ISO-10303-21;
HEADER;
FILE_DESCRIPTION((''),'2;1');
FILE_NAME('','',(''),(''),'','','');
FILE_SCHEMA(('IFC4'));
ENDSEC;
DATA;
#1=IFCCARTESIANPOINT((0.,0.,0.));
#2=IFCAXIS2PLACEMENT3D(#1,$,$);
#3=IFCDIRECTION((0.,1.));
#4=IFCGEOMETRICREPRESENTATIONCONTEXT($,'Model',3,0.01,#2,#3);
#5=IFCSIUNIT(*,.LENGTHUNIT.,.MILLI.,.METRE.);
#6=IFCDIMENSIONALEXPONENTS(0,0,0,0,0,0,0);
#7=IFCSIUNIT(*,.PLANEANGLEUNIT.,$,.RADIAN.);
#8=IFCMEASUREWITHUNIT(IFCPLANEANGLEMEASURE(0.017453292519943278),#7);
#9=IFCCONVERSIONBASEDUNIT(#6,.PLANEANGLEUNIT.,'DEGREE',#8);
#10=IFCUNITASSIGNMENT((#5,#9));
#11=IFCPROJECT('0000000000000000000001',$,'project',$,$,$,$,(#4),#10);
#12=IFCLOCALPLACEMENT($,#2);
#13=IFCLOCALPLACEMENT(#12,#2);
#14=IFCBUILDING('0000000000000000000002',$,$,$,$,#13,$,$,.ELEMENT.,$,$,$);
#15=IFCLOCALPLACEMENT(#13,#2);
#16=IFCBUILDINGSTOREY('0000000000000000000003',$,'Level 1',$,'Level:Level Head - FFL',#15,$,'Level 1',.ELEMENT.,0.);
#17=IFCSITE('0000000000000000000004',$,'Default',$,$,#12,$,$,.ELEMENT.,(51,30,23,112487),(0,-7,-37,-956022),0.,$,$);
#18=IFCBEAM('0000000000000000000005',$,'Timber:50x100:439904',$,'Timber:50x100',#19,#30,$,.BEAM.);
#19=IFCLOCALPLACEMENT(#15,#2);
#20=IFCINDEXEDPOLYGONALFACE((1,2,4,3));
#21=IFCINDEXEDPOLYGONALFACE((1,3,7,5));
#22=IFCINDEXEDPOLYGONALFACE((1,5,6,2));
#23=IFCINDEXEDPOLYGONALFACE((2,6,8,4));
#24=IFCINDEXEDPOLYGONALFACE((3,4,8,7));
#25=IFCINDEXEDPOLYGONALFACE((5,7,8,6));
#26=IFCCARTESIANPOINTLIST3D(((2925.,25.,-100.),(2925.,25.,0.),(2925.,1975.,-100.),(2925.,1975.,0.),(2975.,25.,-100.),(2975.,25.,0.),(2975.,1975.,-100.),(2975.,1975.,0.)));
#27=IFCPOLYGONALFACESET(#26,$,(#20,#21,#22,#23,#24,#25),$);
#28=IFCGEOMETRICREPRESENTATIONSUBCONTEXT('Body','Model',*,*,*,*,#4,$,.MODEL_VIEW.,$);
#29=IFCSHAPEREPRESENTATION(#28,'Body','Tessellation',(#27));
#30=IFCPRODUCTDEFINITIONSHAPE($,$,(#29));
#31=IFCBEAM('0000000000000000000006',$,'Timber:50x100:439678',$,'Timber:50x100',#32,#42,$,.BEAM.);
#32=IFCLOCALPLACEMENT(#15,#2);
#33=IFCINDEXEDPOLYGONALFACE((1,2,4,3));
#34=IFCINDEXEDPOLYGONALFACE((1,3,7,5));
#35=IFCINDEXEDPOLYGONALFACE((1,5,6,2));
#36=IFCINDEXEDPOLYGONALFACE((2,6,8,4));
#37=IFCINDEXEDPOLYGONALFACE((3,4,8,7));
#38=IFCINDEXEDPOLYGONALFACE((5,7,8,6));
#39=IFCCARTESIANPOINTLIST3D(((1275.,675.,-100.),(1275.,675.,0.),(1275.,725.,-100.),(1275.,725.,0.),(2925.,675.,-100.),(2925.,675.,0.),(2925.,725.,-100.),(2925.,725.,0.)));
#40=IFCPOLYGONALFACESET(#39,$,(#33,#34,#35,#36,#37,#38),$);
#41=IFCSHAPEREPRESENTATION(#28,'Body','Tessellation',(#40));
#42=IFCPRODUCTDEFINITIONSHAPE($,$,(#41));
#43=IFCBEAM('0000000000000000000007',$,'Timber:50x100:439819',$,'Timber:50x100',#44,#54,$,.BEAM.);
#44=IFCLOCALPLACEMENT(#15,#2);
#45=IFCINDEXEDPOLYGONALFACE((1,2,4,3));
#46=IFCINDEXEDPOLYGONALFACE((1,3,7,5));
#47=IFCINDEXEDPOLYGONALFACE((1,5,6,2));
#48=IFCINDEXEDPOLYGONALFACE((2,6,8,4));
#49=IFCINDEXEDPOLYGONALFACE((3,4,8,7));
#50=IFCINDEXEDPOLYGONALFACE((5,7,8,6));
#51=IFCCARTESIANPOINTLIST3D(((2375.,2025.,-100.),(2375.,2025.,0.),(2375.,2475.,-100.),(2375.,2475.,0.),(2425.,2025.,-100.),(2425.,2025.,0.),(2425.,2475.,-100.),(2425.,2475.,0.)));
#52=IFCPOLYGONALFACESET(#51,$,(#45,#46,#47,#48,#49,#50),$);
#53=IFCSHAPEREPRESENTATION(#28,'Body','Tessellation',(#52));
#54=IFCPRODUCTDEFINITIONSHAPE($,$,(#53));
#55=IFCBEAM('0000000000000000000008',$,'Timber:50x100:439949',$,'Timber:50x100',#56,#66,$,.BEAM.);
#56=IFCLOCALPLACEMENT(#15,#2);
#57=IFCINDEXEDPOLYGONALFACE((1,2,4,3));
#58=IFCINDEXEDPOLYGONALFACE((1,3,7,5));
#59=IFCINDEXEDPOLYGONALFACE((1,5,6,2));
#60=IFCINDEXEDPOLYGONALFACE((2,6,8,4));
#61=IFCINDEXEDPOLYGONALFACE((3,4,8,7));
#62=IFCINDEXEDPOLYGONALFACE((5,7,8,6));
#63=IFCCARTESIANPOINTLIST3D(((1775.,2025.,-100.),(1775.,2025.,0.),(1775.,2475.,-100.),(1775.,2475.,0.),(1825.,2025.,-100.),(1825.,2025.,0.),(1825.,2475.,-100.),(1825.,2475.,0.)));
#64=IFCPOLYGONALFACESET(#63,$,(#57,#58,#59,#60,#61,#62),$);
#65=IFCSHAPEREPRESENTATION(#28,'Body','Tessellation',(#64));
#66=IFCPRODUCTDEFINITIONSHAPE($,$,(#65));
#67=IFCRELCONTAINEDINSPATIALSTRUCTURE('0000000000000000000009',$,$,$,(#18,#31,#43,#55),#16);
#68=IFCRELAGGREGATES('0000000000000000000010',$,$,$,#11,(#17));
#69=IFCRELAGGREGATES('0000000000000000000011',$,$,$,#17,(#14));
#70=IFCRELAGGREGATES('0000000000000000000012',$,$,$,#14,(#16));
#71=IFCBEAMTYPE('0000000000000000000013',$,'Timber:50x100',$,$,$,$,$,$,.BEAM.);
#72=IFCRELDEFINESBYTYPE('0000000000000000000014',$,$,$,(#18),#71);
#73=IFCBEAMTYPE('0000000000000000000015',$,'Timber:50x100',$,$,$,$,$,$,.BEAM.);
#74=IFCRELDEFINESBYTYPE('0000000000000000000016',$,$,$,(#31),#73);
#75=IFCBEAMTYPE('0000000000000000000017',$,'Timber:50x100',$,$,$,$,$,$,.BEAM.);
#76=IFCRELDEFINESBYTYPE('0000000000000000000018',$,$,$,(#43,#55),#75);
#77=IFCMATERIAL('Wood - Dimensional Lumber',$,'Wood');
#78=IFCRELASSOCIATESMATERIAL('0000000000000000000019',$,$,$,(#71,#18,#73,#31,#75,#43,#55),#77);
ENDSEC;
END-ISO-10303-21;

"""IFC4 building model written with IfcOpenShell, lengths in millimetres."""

from ifc_helpers import new_model, entity, si_unit, converted_unit, direction, frame, origin, place, context, subcontext, project, spatial, indexed_curve, outline, extrude, source, transform, mapped, material, type_object, type_shapes, element, save


model = new_model("IFC4")

# Units and contexts
model_context = context("Model", 3, precision=0.01, world=origin(), true_north=direction((0.0, 1.0)))
body_context = subcontext(model_context, "Body", "Model", "MODEL_VIEW")
ifc_project = project(units=[si_unit("LENGTHUNIT", "METRE", prefix="MILLI"), converted_unit("PLANEANGLEUNIT", "DEGREE", entity("IfcPlaneAngleMeasure", 0.017453292519943278), si_unit("PLANEANGLEUNIT", "RADIAN"), dimensions=[0, 0, 0, 0, 0, 0, 0])], contexts=[model_context])

# Site, building, storey
site_placement = place(None, origin())
site = spatial("IfcSite", under=ifc_project, at=site_placement, Name="Default", CompositionType="ELEMENT", RefLatitude=(51, 30, 23, 112487), RefLongitude=(0, -7, -37, -956022), RefElevation=0.0)
building_placement = place(site_placement, origin())
building = spatial("IfcBuilding", under=site, at=building_placement, CompositionType="ELEMENT")
storey_placement = place(building_placement, origin())
storey = spatial("IfcBuildingStorey", under=building, at=storey_placement, Name="Level 1", ObjectType="Level:Level Head - FFL", LongName="Level 1", CompositionType="ELEMENT", Elevation=0.0)

# Beams
ifc_material = material(Name="Wood - Dimensional Lumber", Category="Wood")
beam_type_1 = type_object("IfcBeamType", Name="Timber:50x100", PredefinedType="BEAM", material=ifc_material)
shared_shape_1 = source(origin(), body_context, "Body", "SweptSolid", [
    extrude(outline(indexed_curve([(-975.0, -25.0), (975.0, -25.0), (975.0, 25.0), (-975.0, 25.0), (-975.0, -25.0)], self_intersect=False)), frame((0.0, 0.0, -50.0), z_axis=(0.0, 0.0, 1.0), x_axis=(-1.0, 0.0, 0.0)), (0.0, 0.0, 1.0), 100.0),
])
type_shapes(beam_type_1, [shared_shape_1])
for number, where, z_axis, x_axis, name in (
    (1, (2950.0, 1000.0, -50.0), (0.0, 0.0, 1.0), (0.0, 1.0, 0.0), "Timber:50x100:439904"),
):
    element("IfcBeam", number, at=place(storey_placement, frame(where, z_axis=z_axis, x_axis=x_axis)), inside=storey, type_object=beam_type_1, material=ifc_material, Name=name, ObjectType="Timber:50x100", PredefinedType="BEAM", context=body_context, shape_type="MappedRepresentation", body=[
        mapped(shared_shape_1, transform((0.0, 0.0, 0.0), scale=1.0)),
    ])
beam_type_2 = type_object("IfcBeamType", Name="Timber:50x100", PredefinedType="BEAM", material=ifc_material)
shared_shape_2 = source(origin(), body_context, "Body", "SweptSolid", [
    extrude(outline(indexed_curve([(-825.0, -25.0), (825.0, -25.0), (825.0, 25.0), (-825.0, 25.0), (-825.0, -25.0)], self_intersect=False)), frame((0.0, 0.0, -50.0), z_axis=(0.0, 0.0, 1.0), x_axis=(-1.0, 0.0, 0.0)), (0.0, 0.0, 1.0), 100.0),
])
type_shapes(beam_type_2, [shared_shape_2])
beam_1_placement = place(storey_placement, frame((2100.0, 700.0, -50.0)))
element("IfcBeam", 2, at=beam_1_placement, inside=storey, type_object=beam_type_2, material=ifc_material, Name="Timber:50x100:439678", ObjectType="Timber:50x100", PredefinedType="BEAM", context=body_context, shape_type="MappedRepresentation", body=[
    mapped(shared_shape_2, transform((0.0, 0.0, 0.0), scale=1.0)),
])
beam_type_3 = type_object("IfcBeamType", Name="Timber:50x100", PredefinedType="BEAM", material=ifc_material)
shared_shape_3 = source(origin(), body_context, "Body", "SweptSolid", [
    extrude(outline(indexed_curve([(-225.0, -25.0), (225.0, -25.0), (225.0, 25.0), (-225.0, 25.0), (-225.0, -25.0)], self_intersect=False)), frame((0.0, 0.0, -50.0), z_axis=(0.0, 0.0, 1.0), x_axis=(-1.0, 0.0, 0.0)), (0.0, 0.0, 1.0), 100.0),
])
type_shapes(beam_type_3, [shared_shape_3])
for number, where, z_axis, x_axis, name in (
    (3, (2400.0, 2250.0, -50.0), (0.0, 0.0, 1.0), (0.0, -1.0, 0.0), "Timber:50x100:439819"),
    (4, (1800.0, 2250.0, -50.0), (0.0, 0.0, 1.0), (0.0, -1.0, 0.0), "Timber:50x100:439949"),
):
    element("IfcBeam", number, at=place(storey_placement, frame(where, z_axis=z_axis, x_axis=x_axis)), inside=storey, type_object=beam_type_3, material=ifc_material, Name=name, ObjectType="Timber:50x100", PredefinedType="BEAM", context=body_context, shape_type="MappedRepresentation", body=[
        mapped(shared_shape_3, transform((0.0, 0.0, 0.0), scale=1.0)),
    ])

save(model, "model.ifc")
